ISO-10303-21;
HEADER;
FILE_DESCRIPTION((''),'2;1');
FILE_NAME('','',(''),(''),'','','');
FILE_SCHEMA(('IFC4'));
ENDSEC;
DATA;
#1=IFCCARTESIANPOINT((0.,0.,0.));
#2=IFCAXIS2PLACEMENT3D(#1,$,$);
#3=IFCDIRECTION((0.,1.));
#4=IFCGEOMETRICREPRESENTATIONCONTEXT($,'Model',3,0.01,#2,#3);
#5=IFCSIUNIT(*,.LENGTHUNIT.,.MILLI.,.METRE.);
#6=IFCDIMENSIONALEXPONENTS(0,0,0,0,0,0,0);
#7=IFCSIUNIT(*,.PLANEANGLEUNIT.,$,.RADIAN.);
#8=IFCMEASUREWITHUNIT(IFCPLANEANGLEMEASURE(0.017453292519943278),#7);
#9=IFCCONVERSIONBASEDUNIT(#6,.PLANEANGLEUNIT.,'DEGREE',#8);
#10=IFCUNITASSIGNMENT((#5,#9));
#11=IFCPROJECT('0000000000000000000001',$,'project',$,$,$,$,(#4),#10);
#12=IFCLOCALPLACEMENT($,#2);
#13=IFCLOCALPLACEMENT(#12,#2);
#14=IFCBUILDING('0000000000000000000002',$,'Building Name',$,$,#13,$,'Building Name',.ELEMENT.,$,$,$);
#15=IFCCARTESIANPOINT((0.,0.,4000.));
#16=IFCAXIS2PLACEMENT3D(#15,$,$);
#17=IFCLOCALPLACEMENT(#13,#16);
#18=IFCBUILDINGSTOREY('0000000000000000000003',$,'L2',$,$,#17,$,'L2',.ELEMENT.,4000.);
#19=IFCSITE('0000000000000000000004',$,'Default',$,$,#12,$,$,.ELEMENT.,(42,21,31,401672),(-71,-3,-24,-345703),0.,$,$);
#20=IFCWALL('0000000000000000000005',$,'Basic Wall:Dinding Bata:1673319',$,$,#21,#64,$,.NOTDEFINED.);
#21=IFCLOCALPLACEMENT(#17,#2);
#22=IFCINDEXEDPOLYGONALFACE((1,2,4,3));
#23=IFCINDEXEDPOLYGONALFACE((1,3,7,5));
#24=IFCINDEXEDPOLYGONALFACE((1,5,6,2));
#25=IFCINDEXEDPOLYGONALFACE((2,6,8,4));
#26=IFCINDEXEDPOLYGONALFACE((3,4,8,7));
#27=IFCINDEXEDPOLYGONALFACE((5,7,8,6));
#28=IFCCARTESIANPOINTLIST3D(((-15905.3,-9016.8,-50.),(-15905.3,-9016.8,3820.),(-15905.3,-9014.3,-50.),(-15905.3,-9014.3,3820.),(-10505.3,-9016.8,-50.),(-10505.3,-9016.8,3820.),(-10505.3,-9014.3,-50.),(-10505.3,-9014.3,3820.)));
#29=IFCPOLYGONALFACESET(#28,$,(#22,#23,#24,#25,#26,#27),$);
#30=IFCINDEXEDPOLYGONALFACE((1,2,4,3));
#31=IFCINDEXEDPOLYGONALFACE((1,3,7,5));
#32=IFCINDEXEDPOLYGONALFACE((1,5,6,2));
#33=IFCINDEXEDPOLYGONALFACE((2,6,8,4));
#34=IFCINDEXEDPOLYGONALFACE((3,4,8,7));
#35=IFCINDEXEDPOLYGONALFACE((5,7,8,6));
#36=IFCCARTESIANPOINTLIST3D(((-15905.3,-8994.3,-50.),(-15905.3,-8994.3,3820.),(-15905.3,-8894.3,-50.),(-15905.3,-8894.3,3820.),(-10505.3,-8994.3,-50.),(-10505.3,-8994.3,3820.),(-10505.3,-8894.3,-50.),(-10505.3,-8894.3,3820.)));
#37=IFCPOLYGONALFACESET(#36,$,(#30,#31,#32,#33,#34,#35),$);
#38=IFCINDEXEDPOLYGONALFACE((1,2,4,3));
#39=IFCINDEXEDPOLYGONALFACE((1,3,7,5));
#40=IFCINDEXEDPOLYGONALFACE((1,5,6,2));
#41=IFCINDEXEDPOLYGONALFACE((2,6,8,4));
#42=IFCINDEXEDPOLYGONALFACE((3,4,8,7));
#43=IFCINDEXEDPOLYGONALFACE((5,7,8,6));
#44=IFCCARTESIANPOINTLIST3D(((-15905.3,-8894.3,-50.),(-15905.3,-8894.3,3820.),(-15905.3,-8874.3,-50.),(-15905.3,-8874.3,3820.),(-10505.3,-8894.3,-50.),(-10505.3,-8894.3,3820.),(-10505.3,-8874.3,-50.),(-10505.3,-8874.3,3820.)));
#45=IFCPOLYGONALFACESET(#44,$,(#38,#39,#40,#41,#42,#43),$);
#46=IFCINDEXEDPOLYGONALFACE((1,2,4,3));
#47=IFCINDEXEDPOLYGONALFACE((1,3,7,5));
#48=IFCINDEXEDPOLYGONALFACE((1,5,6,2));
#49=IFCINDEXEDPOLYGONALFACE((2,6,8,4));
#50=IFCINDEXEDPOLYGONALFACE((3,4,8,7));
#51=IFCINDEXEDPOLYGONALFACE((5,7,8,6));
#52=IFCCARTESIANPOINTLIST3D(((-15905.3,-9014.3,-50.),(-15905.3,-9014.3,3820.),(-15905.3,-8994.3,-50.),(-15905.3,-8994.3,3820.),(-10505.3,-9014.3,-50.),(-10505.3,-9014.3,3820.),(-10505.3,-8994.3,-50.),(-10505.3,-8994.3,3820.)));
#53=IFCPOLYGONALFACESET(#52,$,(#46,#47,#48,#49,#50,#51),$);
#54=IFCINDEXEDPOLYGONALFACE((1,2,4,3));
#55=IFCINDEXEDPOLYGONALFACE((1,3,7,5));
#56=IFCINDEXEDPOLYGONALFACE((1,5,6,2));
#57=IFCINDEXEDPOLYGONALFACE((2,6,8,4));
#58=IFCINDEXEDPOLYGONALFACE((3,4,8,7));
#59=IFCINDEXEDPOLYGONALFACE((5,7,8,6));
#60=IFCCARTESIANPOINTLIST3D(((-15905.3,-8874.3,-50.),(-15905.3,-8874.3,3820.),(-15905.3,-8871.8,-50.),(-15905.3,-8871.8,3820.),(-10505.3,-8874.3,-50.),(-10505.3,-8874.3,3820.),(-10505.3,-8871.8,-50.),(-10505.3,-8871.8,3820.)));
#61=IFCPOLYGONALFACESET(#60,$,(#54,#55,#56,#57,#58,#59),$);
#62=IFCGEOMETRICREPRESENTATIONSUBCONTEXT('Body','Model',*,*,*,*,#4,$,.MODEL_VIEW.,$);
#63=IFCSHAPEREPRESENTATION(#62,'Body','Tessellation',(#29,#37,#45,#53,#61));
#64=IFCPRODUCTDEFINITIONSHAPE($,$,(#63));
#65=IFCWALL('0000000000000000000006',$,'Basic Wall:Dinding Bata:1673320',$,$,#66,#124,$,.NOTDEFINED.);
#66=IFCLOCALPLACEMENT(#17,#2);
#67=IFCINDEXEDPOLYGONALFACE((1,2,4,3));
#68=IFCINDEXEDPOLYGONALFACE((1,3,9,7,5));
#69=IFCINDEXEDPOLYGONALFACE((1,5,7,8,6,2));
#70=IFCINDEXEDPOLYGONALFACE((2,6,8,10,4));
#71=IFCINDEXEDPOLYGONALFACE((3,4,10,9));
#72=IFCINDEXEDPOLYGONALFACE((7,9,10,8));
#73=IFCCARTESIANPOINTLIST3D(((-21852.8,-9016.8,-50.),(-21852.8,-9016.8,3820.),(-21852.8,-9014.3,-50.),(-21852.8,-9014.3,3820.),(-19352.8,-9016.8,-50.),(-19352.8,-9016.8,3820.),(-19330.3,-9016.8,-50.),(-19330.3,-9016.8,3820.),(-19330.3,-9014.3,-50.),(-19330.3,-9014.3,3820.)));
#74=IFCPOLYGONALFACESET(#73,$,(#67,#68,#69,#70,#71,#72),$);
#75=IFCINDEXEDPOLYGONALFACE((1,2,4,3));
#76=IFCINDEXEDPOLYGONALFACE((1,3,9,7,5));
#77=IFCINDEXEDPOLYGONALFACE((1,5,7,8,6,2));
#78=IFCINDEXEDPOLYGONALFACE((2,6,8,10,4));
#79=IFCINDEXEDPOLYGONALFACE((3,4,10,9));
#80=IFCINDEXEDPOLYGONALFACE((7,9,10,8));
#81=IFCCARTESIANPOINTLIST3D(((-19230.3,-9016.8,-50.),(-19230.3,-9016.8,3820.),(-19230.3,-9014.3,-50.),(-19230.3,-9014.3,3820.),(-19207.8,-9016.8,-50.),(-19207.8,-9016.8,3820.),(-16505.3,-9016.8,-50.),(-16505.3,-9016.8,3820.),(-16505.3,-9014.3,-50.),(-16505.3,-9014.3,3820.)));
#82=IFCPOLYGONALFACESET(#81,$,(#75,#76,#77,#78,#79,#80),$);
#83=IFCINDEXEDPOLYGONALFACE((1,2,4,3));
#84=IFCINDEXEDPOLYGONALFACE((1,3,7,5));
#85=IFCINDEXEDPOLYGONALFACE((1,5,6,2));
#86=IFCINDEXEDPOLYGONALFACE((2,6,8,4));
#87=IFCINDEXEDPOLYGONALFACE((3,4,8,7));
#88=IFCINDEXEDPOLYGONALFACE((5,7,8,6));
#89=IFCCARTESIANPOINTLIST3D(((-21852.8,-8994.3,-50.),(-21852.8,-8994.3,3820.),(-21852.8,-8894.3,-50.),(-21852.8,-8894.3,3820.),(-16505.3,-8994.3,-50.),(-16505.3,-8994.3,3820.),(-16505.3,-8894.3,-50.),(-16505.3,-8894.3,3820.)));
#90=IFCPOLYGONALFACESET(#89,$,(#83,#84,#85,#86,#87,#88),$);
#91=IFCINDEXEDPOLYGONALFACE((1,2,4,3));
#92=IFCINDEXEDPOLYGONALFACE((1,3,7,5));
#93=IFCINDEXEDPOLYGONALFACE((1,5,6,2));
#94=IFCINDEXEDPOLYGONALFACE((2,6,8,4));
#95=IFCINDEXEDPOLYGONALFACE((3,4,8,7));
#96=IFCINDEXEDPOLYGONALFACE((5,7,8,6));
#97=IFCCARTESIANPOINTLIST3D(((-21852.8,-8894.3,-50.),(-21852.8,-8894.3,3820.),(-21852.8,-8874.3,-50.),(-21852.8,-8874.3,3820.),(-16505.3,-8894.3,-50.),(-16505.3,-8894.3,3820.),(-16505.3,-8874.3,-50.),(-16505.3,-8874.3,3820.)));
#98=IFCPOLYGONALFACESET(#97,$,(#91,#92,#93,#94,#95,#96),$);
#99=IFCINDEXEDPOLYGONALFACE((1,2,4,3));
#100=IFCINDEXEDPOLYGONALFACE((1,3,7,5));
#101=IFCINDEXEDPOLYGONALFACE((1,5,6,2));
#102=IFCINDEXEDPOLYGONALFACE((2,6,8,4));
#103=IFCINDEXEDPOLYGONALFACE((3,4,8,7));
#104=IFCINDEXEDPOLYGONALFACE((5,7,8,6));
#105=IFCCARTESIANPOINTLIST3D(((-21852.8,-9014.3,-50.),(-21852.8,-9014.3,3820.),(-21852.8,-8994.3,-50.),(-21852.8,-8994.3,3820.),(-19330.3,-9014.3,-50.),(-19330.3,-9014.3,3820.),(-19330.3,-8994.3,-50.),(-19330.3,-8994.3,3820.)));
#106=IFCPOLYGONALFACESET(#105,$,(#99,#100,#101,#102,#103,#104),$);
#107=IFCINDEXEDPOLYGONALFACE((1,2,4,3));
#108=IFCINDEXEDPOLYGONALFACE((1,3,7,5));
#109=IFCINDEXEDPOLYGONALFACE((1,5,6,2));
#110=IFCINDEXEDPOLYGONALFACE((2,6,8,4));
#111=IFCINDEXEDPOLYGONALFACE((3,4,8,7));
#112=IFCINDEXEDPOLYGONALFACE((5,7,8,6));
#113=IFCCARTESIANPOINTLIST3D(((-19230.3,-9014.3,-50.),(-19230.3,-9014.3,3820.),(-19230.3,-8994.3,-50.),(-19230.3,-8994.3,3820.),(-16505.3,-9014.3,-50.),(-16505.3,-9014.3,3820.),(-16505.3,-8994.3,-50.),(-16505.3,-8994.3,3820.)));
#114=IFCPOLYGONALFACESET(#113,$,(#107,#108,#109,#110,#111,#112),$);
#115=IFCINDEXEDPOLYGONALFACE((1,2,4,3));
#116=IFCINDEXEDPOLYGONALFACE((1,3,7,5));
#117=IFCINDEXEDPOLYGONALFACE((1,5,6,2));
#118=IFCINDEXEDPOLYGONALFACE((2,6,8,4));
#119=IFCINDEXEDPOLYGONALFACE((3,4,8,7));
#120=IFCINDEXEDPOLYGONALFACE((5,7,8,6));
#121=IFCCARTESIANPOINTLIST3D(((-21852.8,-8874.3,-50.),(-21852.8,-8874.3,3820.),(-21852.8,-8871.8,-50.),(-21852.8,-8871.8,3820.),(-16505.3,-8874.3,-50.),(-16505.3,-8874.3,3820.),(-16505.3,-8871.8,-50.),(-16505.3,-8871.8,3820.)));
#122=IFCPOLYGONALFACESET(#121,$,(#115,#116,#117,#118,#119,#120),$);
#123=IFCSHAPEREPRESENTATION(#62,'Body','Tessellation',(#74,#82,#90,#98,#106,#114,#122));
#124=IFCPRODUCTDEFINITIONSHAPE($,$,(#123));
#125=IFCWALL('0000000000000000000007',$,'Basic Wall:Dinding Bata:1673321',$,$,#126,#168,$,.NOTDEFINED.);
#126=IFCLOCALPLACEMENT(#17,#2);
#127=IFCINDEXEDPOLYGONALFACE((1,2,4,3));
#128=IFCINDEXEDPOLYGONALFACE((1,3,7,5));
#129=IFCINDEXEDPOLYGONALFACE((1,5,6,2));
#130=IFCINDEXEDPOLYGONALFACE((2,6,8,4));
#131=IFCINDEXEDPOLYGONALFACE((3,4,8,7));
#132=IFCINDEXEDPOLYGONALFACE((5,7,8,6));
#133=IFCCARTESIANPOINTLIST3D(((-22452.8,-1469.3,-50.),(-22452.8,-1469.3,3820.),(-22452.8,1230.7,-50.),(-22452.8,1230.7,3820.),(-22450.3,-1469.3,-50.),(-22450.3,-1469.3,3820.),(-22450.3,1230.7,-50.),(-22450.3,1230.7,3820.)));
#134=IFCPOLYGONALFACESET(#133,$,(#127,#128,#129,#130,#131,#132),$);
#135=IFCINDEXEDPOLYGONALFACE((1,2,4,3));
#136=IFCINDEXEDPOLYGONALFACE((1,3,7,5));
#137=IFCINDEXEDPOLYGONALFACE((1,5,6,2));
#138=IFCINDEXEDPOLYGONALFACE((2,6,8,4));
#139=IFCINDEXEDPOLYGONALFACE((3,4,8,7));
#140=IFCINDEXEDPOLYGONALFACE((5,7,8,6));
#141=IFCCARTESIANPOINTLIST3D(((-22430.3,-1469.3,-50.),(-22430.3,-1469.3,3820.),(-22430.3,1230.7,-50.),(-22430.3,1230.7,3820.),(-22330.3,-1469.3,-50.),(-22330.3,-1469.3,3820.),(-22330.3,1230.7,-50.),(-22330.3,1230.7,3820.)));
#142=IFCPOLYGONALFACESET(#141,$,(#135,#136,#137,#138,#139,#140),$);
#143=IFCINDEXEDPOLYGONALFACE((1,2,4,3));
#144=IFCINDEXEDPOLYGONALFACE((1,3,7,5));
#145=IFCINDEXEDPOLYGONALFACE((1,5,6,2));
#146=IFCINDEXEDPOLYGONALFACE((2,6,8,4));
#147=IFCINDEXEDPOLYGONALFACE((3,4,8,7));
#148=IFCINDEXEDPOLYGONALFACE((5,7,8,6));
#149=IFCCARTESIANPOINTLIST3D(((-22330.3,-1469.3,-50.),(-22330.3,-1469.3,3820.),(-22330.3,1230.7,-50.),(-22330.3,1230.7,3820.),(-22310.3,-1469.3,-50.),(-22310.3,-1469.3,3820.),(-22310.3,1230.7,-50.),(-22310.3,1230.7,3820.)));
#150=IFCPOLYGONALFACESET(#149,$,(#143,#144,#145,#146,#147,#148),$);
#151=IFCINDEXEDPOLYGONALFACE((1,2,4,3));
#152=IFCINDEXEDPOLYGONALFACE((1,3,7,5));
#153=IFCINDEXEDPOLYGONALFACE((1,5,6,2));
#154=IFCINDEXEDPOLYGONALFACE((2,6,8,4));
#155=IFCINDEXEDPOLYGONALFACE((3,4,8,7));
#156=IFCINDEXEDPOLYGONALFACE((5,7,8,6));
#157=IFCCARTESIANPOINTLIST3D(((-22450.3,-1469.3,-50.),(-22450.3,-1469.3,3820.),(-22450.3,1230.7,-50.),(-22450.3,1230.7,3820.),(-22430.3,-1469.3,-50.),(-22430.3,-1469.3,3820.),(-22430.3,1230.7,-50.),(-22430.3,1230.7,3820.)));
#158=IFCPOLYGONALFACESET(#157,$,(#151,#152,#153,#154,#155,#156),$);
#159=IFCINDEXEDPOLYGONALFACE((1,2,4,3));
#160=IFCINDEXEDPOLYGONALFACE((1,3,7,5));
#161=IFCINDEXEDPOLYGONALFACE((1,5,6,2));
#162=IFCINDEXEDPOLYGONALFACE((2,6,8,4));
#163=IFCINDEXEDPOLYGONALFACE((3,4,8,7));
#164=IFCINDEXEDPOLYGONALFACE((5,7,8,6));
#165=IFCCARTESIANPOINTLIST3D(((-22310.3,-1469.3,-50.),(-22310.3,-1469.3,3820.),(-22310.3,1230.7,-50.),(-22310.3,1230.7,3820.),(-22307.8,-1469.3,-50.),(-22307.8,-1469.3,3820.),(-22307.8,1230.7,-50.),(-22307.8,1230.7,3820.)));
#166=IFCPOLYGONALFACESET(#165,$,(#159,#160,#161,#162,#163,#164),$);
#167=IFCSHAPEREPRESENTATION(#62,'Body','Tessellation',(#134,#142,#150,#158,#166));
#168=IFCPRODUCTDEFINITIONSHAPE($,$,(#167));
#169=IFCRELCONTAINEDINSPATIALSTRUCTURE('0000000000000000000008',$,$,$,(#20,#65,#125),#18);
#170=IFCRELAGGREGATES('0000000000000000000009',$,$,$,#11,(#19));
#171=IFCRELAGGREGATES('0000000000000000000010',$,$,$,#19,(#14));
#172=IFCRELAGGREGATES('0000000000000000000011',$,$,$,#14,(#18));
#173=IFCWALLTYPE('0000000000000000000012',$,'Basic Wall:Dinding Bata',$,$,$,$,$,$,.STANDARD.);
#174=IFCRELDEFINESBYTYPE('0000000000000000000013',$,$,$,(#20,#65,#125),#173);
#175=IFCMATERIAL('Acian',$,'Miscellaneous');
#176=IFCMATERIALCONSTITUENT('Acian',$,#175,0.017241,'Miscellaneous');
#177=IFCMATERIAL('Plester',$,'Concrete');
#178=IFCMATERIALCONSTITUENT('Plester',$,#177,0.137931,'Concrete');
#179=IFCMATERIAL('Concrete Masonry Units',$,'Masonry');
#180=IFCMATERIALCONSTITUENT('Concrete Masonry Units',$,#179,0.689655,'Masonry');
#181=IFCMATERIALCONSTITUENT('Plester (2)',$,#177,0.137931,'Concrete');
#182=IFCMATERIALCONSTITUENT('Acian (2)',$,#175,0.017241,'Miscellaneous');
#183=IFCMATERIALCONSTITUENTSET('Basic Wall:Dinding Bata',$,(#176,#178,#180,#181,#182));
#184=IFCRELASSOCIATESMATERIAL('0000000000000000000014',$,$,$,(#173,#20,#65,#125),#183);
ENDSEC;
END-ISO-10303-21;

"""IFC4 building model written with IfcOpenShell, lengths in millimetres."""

from ifc_helpers import new_model, entity, si_unit, converted_unit, direction, frame, origin, place, context, subcontext, project, spatial, indexed_curve, outline, extrude, material, constituent, constituent_set, type_object, element, save


model = new_model("IFC4")

# Units and contexts
model_context = context("Model", 3, precision=0.01, world=origin(), true_north=direction((0.0, 1.0)))
body_context = subcontext(model_context, "Body", "Model", "MODEL_VIEW")
ifc_project = project(units=[si_unit("LENGTHUNIT", "METRE", prefix="MILLI"), converted_unit("PLANEANGLEUNIT", "DEGREE", entity("IfcPlaneAngleMeasure", 0.017453292519943278), si_unit("PLANEANGLEUNIT", "RADIAN"), dimensions=[0, 0, 0, 0, 0, 0, 0])], contexts=[model_context])

# Site, building, storey
site_placement = place(None, origin())
site = spatial("IfcSite", under=ifc_project, at=site_placement, Name="Default", CompositionType="ELEMENT", RefLatitude=(42, 21, 31, 401672), RefLongitude=(-71, -3, -24, -345703), RefElevation=0.0)
building_placement = place(site_placement, origin())
building = spatial("IfcBuilding", under=site, at=building_placement, Name="Building Name", LongName="Building Name", CompositionType="ELEMENT")
storey_placement = place(building_placement, frame((0.0, 0.0, 4000.0)))
storey = spatial("IfcBuildingStorey", under=building, at=storey_placement, Name="L2", LongName="L2", CompositionType="ELEMENT", Elevation=4000.0)

# Walls
ifc_material_1 = material(Name="Acian", Category="Miscellaneous")
ifc_constituent_1 = constituent(ifc_material_1, Name="Acian", Category="Miscellaneous", fraction=0.017241)
ifc_material_2 = material(Name="Plester", Category="Concrete")
ifc_constituent_2 = constituent(ifc_material_2, Name="Plester", Category="Concrete", fraction=0.137931)
ifc_material_3 = material(Name="Concrete Masonry Units", Category="Masonry")
ifc_constituent_3 = constituent(ifc_material_3, Name="Concrete Masonry Units", Category="Masonry", fraction=0.689655)
ifc_constituent_4 = constituent(ifc_material_2, Name="Plester (2)", Category="Concrete", fraction=0.137931)
ifc_constituent_5 = constituent(ifc_material_1, Name="Acian (2)", Category="Miscellaneous", fraction=0.017241)
ifc_constituent_set = constituent_set(constituents=[ifc_constituent_1, ifc_constituent_2, ifc_constituent_3, ifc_constituent_4, ifc_constituent_5], Name="Basic Wall:Dinding Bata")
wall_type = type_object("IfcWallType", Name="Basic Wall:Dinding Bata", PredefinedType="STANDARD", material=ifc_constituent_set)
wall_1_placement = place(storey_placement, frame((-10505.3, -8944.3, -50.0), z_axis=(0.0, 0.0, 1.0), x_axis=(-1.0, 0.0, 0.0)))
element("IfcWall", 1, at=wall_1_placement, inside=storey, type_object=wall_type, material=ifc_constituent_set, Name="Basic Wall:Dinding Bata:1673319", PredefinedType="NOTDEFINED", context=body_context, shape_type="SweptSolid", body=[
    extrude(outline(indexed_curve([(-1.3, -2700.0), (1.2, -2700.0), (1.3, 2700.0), (-1.2, 2700.0), (-1.3, -2700.0)], self_intersect=False)), frame((2700.0, 71.3, 0.0), z_axis=(0.0, 0.0, 1.0), x_axis=(0.0, -1.0, 0.0)), (0.0, 0.0, 1.0), 3870.0),
    extrude(outline(indexed_curve([(-2700.0, -50.0), (2700.0, -50.0), (2700.0, 50.0), (-2700.0, 50.0), (-2700.0, -50.0)], self_intersect=False)), frame((2700.0, 0.0, 0.0)), (0.0, 0.0, 1.0), 3870.0),
    extrude(outline(indexed_curve([(-2700.0, -10.0), (2700.0, -10.0), (2700.0, 10.0), (-2700.0, 10.0), (-2700.0, -10.0)], self_intersect=False)), frame((2700.0, -60.0, 0.0)), (0.0, 0.0, 1.0), 3870.0),
    extrude(outline(indexed_curve([(-2700.0, -10.0), (2700.0, -10.0), (2700.0, 10.0), (-2700.0, 10.0), (-2700.0, -10.0)], self_intersect=False)), frame((2700.0, 60.0, 0.0)), (0.0, 0.0, 1.0), 3870.0),
    extrude(outline(indexed_curve([(-1.3, -2700.0), (1.2, -2700.0), (1.3, 2700.0), (-1.2, 2700.0), (-1.3, -2700.0)], self_intersect=False)), frame((2700.0, -71.3, 0.0), z_axis=(0.0, 0.0, 1.0), x_axis=(0.0, 1.0, 0.0)), (0.0, 0.0, 1.0), 3870.0),
])
wall_2_placement = place(storey_placement, frame((-16505.3, -8944.3, -50.0), z_axis=(0.0, 0.0, 1.0), x_axis=(-1.0, 0.0, 0.0)))
element("IfcWall", 2, at=wall_2_placement, inside=storey, type_object=wall_type, material=ifc_constituent_set, Name="Basic Wall:Dinding Bata:1673320", PredefinedType="NOTDEFINED", context=body_context, shape_type="SweptSolid", body=[
    extrude(outline(indexed_curve([(991.0, -1.0), (1013.5, -1.0), (1013.5, 1.5), (-1509.0, 1.5), (-1509.0, -1.0), (991.0, -1.0)], self_intersect=False)), frame((3838.5, 71.5, 0.0), z_axis=(0.0, 0.0, 1.0), x_axis=(-1.0, 0.0, 0.0)), (0.0, 0.0, 1.0), 3870.0),
    extrude(outline(indexed_curve([(-1630.5, -1.5), (1094.5, -1.5), (1094.5, 1.0), (1072.0, 1.0), (-1630.5, 1.0), (-1630.5, -1.5)], self_intersect=False)), frame((1630.5, 71.5, 0.0)), (0.0, 0.0, 1.0), 3870.0),
    extrude(outline(indexed_curve([(-2673.7, -50.0), (2673.7, -50.0), (2673.7, 50.0), (-2673.7, 50.0), (-2673.7, -50.0)], self_intersect=False)), frame((2673.7, 0.0, 0.0)), (0.0, 0.0, 1.0), 3870.0),
    extrude(outline(indexed_curve([(-2673.7, -10.0), (2673.7, -10.0), (2673.7, 10.0), (-2673.7, 10.0), (-2673.7, -10.0)], self_intersect=False)), frame((2673.7, -60.0, 0.0)), (0.0, 0.0, 1.0), 3870.0),
    extrude(outline(indexed_curve([(-1261.2, -10.0), (1261.2, -10.0), (1261.2, 10.0), (-1261.2, 10.0), (-1261.2, -10.0)], self_intersect=False)), frame((4086.2, 60.0, 0.0), z_axis=(0.0, 0.0, 1.0), x_axis=(-1.0, 0.0, 0.0)), (0.0, 0.0, 1.0), 3870.0),
    extrude(outline(indexed_curve([(-1362.5, -10.0), (1362.5, -10.0), (1362.5, 10.0), (-1362.5, 10.0), (-1362.5, -10.0)], self_intersect=False)), frame((1362.5, 60.0, 0.0)), (0.0, 0.0, 1.0), 3870.0),
    extrude(outline(indexed_curve([(-1.3, -2673.7), (1.2, -2673.7), (1.3, 2673.7), (-1.2, 2673.7), (-1.3, -2673.7)], self_intersect=False)), frame((2673.7, -71.3, 0.0), z_axis=(0.0, 0.0, 1.0), x_axis=(0.0, 1.0, 0.0)), (0.0, 0.0, 1.0), 3870.0),
])
wall_3_placement = place(storey_placement, frame((-22380.3, -1469.3, -50.0), z_axis=(0.0, 0.0, 1.0), x_axis=(0.0, 1.0, 0.0)))
element("IfcWall", 3, at=wall_3_placement, inside=storey, type_object=wall_type, material=ifc_constituent_set, Name="Basic Wall:Dinding Bata:1673321", PredefinedType="NOTDEFINED", context=body_context, shape_type="SweptSolid", body=[
    extrude(outline(indexed_curve([(-1.3, -1350.0), (1.2, -1350.0), (1.2, 1350.0), (-1.2, 1350.0), (-1.3, -1350.0)], self_intersect=False)), frame((1350.0, 71.3, 0.0), z_axis=(0.0, 0.0, 1.0), x_axis=(0.0, -1.0, 0.0)), (0.0, 0.0, 1.0), 3870.0),
    extrude(outline(indexed_curve([(-1350.0, -50.0), (1350.0, -50.0), (1350.0, 50.0), (-1350.0, 50.0), (-1350.0, -50.0)], self_intersect=False)), frame((1350.0, 0.0, 0.0)), (0.0, 0.0, 1.0), 3870.0),
    extrude(outline(indexed_curve([(-1350.0, -10.0), (1350.0, -10.0), (1350.0, 10.0), (-1350.0, 10.0), (-1350.0, -10.0)], self_intersect=False)), frame((1350.0, -60.0, 0.0)), (0.0, 0.0, 1.0), 3870.0),
    extrude(outline(indexed_curve([(-1350.0, -10.0), (1350.0, -10.0), (1350.0, 10.0), (-1350.0, 10.0), (-1350.0, -10.0)], self_intersect=False)), frame((1350.0, 60.0, 0.0)), (0.0, 0.0, 1.0), 3870.0),
    extrude(outline(indexed_curve([(-1.2, -1350.0), (1.2, -1350.0), (1.3, 1350.0), (-1.2, 1350.0), (-1.2, -1350.0)], self_intersect=False)), frame((1350.0, -71.3, 0.0), z_axis=(0.0, 0.0, 1.0), x_axis=(0.0, 1.0, 0.0)), (0.0, 0.0, 1.0), 3870.0),
])

save(model, "model.ifc")
